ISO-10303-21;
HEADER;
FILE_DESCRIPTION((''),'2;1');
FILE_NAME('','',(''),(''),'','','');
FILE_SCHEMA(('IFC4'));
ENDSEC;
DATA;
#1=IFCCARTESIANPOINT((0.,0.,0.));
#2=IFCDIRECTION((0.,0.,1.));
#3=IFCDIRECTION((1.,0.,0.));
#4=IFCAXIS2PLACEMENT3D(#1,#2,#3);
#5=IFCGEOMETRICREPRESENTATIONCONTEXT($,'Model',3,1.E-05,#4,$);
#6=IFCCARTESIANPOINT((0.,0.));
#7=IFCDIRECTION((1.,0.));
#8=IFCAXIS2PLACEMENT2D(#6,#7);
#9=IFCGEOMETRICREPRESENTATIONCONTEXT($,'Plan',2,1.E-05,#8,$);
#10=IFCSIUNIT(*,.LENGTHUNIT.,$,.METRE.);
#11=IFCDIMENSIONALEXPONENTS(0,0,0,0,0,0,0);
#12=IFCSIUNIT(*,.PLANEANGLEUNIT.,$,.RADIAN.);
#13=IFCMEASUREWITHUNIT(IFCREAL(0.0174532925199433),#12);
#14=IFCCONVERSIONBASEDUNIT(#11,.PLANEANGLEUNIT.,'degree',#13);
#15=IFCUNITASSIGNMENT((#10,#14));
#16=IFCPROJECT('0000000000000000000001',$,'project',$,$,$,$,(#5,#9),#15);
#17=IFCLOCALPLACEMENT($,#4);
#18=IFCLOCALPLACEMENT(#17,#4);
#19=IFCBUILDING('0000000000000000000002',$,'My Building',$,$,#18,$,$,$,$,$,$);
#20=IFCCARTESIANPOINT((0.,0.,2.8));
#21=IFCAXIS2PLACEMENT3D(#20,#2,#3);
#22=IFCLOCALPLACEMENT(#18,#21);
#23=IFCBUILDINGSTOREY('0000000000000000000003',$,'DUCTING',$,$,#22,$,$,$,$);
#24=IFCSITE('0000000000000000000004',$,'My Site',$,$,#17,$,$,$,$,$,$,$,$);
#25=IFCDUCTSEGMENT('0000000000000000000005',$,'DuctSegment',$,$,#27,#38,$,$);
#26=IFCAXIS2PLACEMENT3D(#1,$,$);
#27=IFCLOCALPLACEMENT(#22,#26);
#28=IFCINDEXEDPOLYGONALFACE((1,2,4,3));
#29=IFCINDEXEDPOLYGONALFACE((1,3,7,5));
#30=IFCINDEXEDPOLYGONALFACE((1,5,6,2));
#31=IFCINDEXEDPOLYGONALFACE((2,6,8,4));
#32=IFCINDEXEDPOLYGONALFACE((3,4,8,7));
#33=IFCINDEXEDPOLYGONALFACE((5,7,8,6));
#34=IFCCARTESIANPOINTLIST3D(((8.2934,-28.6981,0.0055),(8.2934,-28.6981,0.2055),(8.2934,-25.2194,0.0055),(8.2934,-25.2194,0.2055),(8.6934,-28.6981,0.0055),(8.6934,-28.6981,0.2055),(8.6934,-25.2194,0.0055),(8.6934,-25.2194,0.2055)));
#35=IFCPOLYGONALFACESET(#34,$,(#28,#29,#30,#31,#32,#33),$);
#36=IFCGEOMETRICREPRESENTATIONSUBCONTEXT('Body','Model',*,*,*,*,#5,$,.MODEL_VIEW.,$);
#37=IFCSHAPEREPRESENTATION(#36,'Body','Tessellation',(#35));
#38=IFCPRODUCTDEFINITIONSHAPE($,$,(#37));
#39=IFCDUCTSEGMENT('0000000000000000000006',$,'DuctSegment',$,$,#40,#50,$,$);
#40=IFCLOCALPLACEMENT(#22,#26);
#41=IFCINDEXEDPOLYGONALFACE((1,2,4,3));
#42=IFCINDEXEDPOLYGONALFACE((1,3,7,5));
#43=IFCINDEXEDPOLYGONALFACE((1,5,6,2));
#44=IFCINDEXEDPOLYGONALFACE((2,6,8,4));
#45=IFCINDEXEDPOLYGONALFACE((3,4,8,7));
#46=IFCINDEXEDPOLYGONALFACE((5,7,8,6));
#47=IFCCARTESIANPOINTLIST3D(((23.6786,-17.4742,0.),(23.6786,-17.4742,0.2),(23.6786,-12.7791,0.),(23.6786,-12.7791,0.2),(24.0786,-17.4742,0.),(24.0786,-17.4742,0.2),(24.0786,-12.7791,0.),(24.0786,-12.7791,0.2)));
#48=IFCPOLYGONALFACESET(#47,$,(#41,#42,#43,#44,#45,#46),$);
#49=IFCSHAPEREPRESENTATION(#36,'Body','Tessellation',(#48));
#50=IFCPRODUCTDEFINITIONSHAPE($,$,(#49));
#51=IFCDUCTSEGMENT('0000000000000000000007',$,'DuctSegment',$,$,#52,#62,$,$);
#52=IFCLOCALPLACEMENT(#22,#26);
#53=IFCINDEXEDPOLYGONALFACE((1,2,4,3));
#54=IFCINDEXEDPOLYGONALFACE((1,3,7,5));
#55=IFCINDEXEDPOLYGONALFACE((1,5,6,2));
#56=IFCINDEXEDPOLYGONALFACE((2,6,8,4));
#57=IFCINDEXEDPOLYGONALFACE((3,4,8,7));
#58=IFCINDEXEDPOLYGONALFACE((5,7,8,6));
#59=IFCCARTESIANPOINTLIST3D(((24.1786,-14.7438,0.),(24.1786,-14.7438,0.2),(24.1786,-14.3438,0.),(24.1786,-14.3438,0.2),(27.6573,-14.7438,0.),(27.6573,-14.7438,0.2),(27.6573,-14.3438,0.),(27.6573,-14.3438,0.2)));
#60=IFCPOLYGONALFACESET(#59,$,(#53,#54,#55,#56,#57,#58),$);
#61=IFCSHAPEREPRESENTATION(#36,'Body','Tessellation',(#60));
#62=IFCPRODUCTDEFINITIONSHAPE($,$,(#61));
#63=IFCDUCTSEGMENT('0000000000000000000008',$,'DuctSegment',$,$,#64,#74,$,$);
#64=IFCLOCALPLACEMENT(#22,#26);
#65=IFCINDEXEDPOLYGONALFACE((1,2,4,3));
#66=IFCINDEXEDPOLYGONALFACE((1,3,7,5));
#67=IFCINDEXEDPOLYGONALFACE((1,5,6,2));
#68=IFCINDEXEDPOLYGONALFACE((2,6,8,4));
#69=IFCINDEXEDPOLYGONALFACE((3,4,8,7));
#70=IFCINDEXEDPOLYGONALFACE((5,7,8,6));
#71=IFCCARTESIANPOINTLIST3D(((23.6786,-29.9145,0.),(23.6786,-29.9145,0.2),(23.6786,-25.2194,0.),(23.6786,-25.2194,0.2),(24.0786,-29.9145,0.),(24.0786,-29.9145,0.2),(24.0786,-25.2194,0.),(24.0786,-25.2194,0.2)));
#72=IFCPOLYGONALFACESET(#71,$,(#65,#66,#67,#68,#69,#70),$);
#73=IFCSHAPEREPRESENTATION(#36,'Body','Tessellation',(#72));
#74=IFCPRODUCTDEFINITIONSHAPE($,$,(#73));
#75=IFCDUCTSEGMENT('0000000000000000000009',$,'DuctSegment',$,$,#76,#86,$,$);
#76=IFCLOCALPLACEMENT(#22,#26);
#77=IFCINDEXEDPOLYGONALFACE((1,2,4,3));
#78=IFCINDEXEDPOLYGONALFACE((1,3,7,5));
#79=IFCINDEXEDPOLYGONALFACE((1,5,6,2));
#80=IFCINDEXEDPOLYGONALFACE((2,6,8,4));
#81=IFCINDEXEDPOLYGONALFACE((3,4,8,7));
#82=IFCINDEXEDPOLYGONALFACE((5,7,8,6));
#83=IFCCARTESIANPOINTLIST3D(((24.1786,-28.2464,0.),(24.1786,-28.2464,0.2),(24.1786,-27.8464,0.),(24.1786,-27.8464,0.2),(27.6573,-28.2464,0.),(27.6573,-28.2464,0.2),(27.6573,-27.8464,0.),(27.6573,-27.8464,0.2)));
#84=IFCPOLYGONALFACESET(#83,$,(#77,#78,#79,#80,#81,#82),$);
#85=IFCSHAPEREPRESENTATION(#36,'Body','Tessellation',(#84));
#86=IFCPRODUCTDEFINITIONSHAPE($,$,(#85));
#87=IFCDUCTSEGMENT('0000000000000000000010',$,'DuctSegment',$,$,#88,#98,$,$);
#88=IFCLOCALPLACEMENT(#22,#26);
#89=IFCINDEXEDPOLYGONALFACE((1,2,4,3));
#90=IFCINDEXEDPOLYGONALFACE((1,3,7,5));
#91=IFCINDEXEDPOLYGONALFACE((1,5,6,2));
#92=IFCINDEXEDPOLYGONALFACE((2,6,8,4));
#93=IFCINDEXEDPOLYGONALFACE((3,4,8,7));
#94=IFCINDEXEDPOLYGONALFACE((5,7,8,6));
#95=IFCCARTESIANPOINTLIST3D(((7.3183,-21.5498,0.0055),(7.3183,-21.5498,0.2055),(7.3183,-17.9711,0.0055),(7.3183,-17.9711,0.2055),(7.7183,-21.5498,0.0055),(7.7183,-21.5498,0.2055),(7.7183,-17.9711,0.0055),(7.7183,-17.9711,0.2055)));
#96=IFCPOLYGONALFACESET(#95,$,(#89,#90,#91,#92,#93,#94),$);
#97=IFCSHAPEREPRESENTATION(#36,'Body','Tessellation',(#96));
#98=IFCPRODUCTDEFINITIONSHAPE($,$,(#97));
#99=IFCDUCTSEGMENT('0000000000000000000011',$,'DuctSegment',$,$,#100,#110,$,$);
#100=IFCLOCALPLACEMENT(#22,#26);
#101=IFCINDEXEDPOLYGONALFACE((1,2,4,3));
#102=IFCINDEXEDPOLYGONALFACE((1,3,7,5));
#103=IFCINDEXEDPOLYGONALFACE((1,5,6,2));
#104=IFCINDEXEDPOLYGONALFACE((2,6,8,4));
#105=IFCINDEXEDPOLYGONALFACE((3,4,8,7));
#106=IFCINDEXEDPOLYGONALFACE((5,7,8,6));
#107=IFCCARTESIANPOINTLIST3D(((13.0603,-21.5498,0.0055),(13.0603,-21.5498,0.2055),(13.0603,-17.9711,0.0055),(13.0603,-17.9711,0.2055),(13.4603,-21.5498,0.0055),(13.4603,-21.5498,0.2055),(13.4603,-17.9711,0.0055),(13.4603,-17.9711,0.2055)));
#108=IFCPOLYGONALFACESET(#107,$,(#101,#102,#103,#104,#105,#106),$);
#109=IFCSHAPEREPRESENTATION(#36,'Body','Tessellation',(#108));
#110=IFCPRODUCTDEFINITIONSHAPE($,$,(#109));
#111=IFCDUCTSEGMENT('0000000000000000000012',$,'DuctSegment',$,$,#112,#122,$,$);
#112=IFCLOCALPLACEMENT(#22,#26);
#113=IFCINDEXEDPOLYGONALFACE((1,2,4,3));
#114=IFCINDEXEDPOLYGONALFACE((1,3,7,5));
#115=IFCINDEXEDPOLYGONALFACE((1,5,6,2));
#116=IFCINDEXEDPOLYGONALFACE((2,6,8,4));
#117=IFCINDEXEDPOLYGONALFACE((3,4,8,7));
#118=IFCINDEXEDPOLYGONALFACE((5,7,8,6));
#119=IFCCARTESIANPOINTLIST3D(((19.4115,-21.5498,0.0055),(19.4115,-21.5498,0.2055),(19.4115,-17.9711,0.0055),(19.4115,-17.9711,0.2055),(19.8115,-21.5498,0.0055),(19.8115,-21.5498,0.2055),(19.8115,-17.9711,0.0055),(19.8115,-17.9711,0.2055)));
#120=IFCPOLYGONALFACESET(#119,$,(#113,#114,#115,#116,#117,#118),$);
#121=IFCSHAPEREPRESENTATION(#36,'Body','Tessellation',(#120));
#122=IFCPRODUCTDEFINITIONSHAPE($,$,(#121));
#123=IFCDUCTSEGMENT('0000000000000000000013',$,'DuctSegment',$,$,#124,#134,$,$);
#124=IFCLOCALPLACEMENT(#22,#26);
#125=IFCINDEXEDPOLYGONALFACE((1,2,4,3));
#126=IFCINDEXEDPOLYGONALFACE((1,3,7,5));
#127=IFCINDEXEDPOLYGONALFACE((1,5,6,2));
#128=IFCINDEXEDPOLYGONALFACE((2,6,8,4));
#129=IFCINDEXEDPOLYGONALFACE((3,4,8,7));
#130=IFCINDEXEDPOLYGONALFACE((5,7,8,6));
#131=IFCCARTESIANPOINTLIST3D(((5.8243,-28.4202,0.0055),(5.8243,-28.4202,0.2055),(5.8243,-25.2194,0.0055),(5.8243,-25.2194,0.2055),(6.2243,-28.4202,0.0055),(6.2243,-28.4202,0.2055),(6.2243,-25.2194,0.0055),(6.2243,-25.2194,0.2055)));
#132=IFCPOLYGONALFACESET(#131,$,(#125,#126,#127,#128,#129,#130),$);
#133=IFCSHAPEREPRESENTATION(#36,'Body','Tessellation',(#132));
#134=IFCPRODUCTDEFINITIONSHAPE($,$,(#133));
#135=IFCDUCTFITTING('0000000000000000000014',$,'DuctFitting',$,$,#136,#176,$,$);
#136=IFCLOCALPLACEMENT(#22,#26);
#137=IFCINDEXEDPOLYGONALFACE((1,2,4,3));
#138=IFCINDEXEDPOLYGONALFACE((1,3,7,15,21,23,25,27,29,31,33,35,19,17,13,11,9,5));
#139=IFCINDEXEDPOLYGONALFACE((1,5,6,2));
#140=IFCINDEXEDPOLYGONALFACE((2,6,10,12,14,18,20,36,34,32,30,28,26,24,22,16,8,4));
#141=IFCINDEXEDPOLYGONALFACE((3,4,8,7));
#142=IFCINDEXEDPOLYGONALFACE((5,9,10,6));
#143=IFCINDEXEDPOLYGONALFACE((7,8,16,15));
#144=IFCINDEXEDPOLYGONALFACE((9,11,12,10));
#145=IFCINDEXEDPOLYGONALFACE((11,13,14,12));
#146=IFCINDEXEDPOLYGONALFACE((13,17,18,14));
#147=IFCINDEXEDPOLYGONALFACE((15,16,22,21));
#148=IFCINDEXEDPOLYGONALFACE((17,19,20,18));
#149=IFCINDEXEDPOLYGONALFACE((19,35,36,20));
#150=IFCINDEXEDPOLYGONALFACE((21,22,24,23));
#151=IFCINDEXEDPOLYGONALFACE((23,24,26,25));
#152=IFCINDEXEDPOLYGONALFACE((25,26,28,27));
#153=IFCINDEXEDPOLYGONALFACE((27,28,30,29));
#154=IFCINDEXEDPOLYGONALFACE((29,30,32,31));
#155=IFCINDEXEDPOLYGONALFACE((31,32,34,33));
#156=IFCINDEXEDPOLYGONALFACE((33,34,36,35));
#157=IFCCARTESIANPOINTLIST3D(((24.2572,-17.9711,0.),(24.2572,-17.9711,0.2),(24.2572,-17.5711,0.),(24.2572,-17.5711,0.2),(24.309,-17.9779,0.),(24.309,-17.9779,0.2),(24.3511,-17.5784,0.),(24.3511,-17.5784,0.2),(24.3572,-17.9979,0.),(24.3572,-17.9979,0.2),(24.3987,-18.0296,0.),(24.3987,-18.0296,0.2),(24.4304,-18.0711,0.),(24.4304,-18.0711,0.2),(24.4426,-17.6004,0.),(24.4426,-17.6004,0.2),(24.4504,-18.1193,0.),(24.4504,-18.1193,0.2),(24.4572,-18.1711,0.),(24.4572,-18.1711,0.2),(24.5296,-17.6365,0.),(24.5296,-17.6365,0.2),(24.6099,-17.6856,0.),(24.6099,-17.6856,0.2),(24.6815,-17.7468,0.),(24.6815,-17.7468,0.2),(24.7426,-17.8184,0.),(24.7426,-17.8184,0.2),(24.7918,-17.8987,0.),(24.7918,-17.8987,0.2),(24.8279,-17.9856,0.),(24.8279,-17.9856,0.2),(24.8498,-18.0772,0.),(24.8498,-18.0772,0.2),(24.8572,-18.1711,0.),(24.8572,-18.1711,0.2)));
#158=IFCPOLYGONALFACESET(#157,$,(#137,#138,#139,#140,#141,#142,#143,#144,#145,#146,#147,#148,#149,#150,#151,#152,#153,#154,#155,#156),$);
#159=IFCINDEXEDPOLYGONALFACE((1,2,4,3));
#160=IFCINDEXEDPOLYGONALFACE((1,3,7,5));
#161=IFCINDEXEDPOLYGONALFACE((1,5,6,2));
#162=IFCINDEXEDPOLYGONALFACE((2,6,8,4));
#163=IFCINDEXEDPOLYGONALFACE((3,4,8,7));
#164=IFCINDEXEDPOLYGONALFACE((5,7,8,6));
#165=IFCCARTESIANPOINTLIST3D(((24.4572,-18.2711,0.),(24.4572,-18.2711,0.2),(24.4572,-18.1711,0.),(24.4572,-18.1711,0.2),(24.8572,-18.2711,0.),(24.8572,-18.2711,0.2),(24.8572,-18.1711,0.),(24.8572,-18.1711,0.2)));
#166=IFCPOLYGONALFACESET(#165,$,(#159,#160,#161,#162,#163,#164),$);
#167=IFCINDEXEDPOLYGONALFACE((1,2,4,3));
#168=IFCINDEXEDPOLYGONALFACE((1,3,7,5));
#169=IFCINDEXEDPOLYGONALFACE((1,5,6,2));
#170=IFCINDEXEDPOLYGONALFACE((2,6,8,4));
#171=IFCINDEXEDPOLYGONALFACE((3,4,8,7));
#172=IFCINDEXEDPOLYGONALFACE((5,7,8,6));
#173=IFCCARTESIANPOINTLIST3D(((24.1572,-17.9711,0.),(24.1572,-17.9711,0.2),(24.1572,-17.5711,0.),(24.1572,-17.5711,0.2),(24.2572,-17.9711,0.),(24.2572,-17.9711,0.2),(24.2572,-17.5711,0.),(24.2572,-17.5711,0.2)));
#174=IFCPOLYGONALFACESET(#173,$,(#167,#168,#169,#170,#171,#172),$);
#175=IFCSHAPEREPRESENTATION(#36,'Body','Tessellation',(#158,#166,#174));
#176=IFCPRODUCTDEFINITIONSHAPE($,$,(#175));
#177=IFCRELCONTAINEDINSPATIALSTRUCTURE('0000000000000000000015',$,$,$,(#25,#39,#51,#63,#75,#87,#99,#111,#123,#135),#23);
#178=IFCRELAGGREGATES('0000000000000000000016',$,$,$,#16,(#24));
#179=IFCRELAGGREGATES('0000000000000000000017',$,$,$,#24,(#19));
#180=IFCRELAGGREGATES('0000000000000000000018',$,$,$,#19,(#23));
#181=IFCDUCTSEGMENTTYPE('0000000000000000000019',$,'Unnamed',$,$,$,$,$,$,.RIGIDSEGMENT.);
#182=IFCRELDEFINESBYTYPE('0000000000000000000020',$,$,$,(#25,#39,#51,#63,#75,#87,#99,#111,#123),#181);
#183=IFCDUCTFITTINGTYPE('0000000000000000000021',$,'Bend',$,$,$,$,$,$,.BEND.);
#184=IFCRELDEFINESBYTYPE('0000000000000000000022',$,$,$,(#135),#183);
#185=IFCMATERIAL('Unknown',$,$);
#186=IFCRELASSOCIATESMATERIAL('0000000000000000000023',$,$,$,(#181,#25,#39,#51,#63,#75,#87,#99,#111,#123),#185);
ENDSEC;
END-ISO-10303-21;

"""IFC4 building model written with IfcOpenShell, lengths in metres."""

from ifc_helpers import new_model, entity, si_unit, converted_unit, frame, origin_with_axes, origin_2d_with_axis, place, context, subcontext, project, spatial, line, arc, indexed_curve, rectangle, outline, extrude, source, transform, mapped, material, material_profile, profile_set, profile_usage, type_object, type_shapes, element, save


model = new_model("IFC4")

# Units and contexts
model_context = context("Model", 3, precision=1e-05, world=origin_with_axes())
plan_context = context("Plan", 2, precision=1e-05, world=origin_2d_with_axis())
body_context = subcontext(model_context, "Body", "Model", "MODEL_VIEW")
ifc_project = project(units=[si_unit("LENGTHUNIT", "METRE"), converted_unit("PLANEANGLEUNIT", "degree", entity("IfcReal", 0.0174532925199433), si_unit("PLANEANGLEUNIT", "RADIAN"), dimensions=[0, 0, 0, 0, 0, 0, 0])], contexts=[model_context, plan_context])

# Site, building, storey
site_placement = place(None, origin_with_axes())
site = spatial("IfcSite", under=ifc_project, at=site_placement, Name="My Site")
building_placement = place(site_placement, origin_with_axes())
building = spatial("IfcBuilding", under=site, at=building_placement, Name="My Building")
storey_placement = place(building_placement, frame((0.0, 0.0, 2.8), z_axis=(0.0, 0.0, 1.0), x_axis=(1.0, 0.0, 0.0)))
storey = spatial("IfcBuildingStorey", under=building, at=storey_placement, Name="DUCTING")

# Duct segments
ifc_material = material(Name="Unknown")
ifc_material_profile = material_profile(ifc_material, rectangle(XDim=0.4, YDim=0.2))
ifc_profile_set = profile_set([ifc_material_profile])
duct_segment_type = type_object("IfcDuctSegmentType", Name="Unnamed", PredefinedType="RIGIDSEGMENT", material=ifc_profile_set)
ifc_profile_usage_1 = profile_usage(ifc_profile_set, cardinal=5)
duct_segment_1_placement = place(storey_placement, frame((8.4934, -25.2194, 0.1055), z_axis=(0.0, -1.0, 0.0), x_axis=(1.0, 0.0, 0.0)))
element("IfcDuctSegment", 1, at=duct_segment_1_placement, inside=storey, type_object=duct_segment_type, material=ifc_profile_usage_1, Name="DuctSegment", context=body_context, shape_type="SweptSolid", body=[
    extrude(rectangle(XDim=0.4, YDim=0.2), origin_with_axes(), (0.0, 0.0, 1.0), 3.4787),
])
ifc_profile_usage_2 = profile_usage(ifc_profile_set, cardinal=5)
duct_segment_2_placement = place(storey_placement, frame((23.8786, -17.4742, 0.1), z_axis=(0.0, 1.0, 0.0), x_axis=(-1.0, 0.0, 0.0)))
element("IfcDuctSegment", 2, at=duct_segment_2_placement, inside=storey, type_object=duct_segment_type, material=ifc_profile_usage_2, Name="DuctSegment", context=body_context, shape_type="SweptSolid", body=[
    extrude(rectangle(XDim=0.4, YDim=0.2), origin_with_axes(), (0.0, 0.0, 1.0), 4.6951),
])
ifc_profile_usage_3 = profile_usage(ifc_profile_set, cardinal=5)
duct_segment_3_placement = place(storey_placement, frame((24.1786, -14.5438, 0.1), z_axis=(1.0, 0.0, 0.0), x_axis=(0.0, 1.0, 0.0)))
element("IfcDuctSegment", 3, at=duct_segment_3_placement, inside=storey, type_object=duct_segment_type, material=ifc_profile_usage_3, Name="DuctSegment", context=body_context, shape_type="SweptSolid", body=[
    extrude(rectangle(XDim=0.4, YDim=0.2), origin_with_axes(), (0.0, 0.0, 1.0), 3.4787),
])
ifc_profile_usage_4 = profile_usage(ifc_profile_set, cardinal=5)
duct_segment_4_placement = place(storey_placement, frame((23.8786, -25.2194, 0.1), z_axis=(0.0, -1.0, 0.0), x_axis=(1.0, 0.0, 0.0)))
element("IfcDuctSegment", 4, at=duct_segment_4_placement, inside=storey, type_object=duct_segment_type, material=ifc_profile_usage_4, Name="DuctSegment", context=body_context, shape_type="SweptSolid", body=[
    extrude(rectangle(XDim=0.4, YDim=0.2), origin_with_axes(), (0.0, 0.0, 1.0), 4.6951),
])
ifc_profile_usage_5 = profile_usage(ifc_profile_set, cardinal=5)
duct_segment_5_placement = place(storey_placement, frame((24.1786, -28.0464, 0.1), z_axis=(1.0, 0.0, 0.0), x_axis=(0.0, 1.0, 0.0)))
element("IfcDuctSegment", 5, at=duct_segment_5_placement, inside=storey, type_object=duct_segment_type, material=ifc_profile_usage_5, Name="DuctSegment", context=body_context, shape_type="SweptSolid", body=[
    extrude(rectangle(XDim=0.4, YDim=0.2), origin_with_axes(), (0.0, 0.0, 1.0), 3.4787),
])
ifc_profile_usage_6 = profile_usage(ifc_profile_set, cardinal=5)
duct_segment_6_placement = place(storey_placement, frame((7.5183, -17.9711, 0.1055), z_axis=(0.0, -1.0, 0.0), x_axis=(1.0, 0.0, 0.0)))
element("IfcDuctSegment", 6, at=duct_segment_6_placement, inside=storey, type_object=duct_segment_type, material=ifc_profile_usage_6, Name="DuctSegment", context=body_context, shape_type="SweptSolid", body=[
    extrude(rectangle(XDim=0.4, YDim=0.2), origin_with_axes(), (0.0, 0.0, 1.0), 3.5787),
])
ifc_profile_usage_7 = profile_usage(ifc_profile_set, cardinal=5)
duct_segment_7_placement = place(storey_placement, frame((13.2603, -17.9711, 0.1055), z_axis=(0.0, -1.0, 0.0), x_axis=(1.0, 0.0, 0.0)))
element("IfcDuctSegment", 7, at=duct_segment_7_placement, inside=storey, type_object=duct_segment_type, material=ifc_profile_usage_7, Name="DuctSegment", context=body_context, shape_type="SweptSolid", body=[
    extrude(rectangle(XDim=0.4, YDim=0.2), origin_with_axes(), (0.0, 0.0, 1.0), 3.5787),
])
ifc_profile_usage_8 = profile_usage(ifc_profile_set, cardinal=5)
duct_segment_8_placement = place(storey_placement, frame((19.6115, -17.9711, 0.1055), z_axis=(0.0, -1.0, 0.0), x_axis=(1.0, 0.0, 0.0)))
element("IfcDuctSegment", 8, at=duct_segment_8_placement, inside=storey, type_object=duct_segment_type, material=ifc_profile_usage_8, Name="DuctSegment", context=body_context, shape_type="SweptSolid", body=[
    extrude(rectangle(XDim=0.4, YDim=0.2), origin_with_axes(), (0.0, 0.0, 1.0), 3.5787),
])
ifc_profile_usage_9 = profile_usage(ifc_profile_set, cardinal=5)
duct_segment_9_placement = place(storey_placement, frame((6.0243, -25.2194, 0.1055), z_axis=(0.0, -1.0, 0.0), x_axis=(1.0, 0.0, 0.0)))
element("IfcDuctSegment", 9, at=duct_segment_9_placement, inside=storey, type_object=duct_segment_type, material=ifc_profile_usage_9, Name="DuctSegment", context=body_context, shape_type="SweptSolid", body=[
    extrude(rectangle(XDim=0.4, YDim=0.2), origin_with_axes(), (0.0, 0.0, 1.0), 3.2008),
])

# Duct fitting
duct_fitting_type = type_object("IfcDuctFittingType", Name="Bend", PredefinedType="BEND")
shared_shape = source(origin_with_axes(), body_context, "Body", "SweptSolid", [
    extrude(outline(indexed_curve([(-0.2, 0.0), (-0.2586, -0.1414), (-0.4, -0.2), (-0.4, -0.6), (0.0243, -0.4243), (0.2, 0.0)], segments=[arc(1, 2, 3), line(3, 4), arc(4, 5, 6), line(6, 1)])), frame((0.0, -0.1, -0.1), z_axis=(0.0, -1.0, 0.0), x_axis=(1.0, 0.0, 0.0)), (0.0, 0.0, -1.0), 0.2),
    extrude(rectangle(XDim=0.4, YDim=0.2), origin_with_axes(), (0.0, 0.0, -1.0), 0.1),
    extrude(rectangle(XDim=0.4, YDim=0.2), frame((-0.4, 0.0, -0.5), z_axis=(-1.0, 0.0, 0.0), x_axis=(0.0, 0.0, -1.0)), (0.0, 0.0, 1.0), 0.1),
])
type_shapes(duct_fitting_type, [shared_shape])
for number, where, z_axis, x_axis, name in (
    (10, (24.6572, -18.2711, 0.1), (0.0, -1.0, 0.0), (1.0, 0.0, 0.0), "DuctFitting"),
):
    element("IfcDuctFitting", number, at=place(storey_placement, frame(where, z_axis=z_axis, x_axis=x_axis)), inside=storey, type_object=duct_fitting_type, Name=name, context=body_context, shape_type="MappedRepresentation", body=[
        mapped(shared_shape, transform((0.0, 0.0, 0.0), x_axis=(1.0, 0.0, 0.0), y_axis=(0.0, 1.0, 0.0), z_axis=(0.0, 0.0, 1.0), scale=1.0)),
    ])

save(model, "model.ifc")
